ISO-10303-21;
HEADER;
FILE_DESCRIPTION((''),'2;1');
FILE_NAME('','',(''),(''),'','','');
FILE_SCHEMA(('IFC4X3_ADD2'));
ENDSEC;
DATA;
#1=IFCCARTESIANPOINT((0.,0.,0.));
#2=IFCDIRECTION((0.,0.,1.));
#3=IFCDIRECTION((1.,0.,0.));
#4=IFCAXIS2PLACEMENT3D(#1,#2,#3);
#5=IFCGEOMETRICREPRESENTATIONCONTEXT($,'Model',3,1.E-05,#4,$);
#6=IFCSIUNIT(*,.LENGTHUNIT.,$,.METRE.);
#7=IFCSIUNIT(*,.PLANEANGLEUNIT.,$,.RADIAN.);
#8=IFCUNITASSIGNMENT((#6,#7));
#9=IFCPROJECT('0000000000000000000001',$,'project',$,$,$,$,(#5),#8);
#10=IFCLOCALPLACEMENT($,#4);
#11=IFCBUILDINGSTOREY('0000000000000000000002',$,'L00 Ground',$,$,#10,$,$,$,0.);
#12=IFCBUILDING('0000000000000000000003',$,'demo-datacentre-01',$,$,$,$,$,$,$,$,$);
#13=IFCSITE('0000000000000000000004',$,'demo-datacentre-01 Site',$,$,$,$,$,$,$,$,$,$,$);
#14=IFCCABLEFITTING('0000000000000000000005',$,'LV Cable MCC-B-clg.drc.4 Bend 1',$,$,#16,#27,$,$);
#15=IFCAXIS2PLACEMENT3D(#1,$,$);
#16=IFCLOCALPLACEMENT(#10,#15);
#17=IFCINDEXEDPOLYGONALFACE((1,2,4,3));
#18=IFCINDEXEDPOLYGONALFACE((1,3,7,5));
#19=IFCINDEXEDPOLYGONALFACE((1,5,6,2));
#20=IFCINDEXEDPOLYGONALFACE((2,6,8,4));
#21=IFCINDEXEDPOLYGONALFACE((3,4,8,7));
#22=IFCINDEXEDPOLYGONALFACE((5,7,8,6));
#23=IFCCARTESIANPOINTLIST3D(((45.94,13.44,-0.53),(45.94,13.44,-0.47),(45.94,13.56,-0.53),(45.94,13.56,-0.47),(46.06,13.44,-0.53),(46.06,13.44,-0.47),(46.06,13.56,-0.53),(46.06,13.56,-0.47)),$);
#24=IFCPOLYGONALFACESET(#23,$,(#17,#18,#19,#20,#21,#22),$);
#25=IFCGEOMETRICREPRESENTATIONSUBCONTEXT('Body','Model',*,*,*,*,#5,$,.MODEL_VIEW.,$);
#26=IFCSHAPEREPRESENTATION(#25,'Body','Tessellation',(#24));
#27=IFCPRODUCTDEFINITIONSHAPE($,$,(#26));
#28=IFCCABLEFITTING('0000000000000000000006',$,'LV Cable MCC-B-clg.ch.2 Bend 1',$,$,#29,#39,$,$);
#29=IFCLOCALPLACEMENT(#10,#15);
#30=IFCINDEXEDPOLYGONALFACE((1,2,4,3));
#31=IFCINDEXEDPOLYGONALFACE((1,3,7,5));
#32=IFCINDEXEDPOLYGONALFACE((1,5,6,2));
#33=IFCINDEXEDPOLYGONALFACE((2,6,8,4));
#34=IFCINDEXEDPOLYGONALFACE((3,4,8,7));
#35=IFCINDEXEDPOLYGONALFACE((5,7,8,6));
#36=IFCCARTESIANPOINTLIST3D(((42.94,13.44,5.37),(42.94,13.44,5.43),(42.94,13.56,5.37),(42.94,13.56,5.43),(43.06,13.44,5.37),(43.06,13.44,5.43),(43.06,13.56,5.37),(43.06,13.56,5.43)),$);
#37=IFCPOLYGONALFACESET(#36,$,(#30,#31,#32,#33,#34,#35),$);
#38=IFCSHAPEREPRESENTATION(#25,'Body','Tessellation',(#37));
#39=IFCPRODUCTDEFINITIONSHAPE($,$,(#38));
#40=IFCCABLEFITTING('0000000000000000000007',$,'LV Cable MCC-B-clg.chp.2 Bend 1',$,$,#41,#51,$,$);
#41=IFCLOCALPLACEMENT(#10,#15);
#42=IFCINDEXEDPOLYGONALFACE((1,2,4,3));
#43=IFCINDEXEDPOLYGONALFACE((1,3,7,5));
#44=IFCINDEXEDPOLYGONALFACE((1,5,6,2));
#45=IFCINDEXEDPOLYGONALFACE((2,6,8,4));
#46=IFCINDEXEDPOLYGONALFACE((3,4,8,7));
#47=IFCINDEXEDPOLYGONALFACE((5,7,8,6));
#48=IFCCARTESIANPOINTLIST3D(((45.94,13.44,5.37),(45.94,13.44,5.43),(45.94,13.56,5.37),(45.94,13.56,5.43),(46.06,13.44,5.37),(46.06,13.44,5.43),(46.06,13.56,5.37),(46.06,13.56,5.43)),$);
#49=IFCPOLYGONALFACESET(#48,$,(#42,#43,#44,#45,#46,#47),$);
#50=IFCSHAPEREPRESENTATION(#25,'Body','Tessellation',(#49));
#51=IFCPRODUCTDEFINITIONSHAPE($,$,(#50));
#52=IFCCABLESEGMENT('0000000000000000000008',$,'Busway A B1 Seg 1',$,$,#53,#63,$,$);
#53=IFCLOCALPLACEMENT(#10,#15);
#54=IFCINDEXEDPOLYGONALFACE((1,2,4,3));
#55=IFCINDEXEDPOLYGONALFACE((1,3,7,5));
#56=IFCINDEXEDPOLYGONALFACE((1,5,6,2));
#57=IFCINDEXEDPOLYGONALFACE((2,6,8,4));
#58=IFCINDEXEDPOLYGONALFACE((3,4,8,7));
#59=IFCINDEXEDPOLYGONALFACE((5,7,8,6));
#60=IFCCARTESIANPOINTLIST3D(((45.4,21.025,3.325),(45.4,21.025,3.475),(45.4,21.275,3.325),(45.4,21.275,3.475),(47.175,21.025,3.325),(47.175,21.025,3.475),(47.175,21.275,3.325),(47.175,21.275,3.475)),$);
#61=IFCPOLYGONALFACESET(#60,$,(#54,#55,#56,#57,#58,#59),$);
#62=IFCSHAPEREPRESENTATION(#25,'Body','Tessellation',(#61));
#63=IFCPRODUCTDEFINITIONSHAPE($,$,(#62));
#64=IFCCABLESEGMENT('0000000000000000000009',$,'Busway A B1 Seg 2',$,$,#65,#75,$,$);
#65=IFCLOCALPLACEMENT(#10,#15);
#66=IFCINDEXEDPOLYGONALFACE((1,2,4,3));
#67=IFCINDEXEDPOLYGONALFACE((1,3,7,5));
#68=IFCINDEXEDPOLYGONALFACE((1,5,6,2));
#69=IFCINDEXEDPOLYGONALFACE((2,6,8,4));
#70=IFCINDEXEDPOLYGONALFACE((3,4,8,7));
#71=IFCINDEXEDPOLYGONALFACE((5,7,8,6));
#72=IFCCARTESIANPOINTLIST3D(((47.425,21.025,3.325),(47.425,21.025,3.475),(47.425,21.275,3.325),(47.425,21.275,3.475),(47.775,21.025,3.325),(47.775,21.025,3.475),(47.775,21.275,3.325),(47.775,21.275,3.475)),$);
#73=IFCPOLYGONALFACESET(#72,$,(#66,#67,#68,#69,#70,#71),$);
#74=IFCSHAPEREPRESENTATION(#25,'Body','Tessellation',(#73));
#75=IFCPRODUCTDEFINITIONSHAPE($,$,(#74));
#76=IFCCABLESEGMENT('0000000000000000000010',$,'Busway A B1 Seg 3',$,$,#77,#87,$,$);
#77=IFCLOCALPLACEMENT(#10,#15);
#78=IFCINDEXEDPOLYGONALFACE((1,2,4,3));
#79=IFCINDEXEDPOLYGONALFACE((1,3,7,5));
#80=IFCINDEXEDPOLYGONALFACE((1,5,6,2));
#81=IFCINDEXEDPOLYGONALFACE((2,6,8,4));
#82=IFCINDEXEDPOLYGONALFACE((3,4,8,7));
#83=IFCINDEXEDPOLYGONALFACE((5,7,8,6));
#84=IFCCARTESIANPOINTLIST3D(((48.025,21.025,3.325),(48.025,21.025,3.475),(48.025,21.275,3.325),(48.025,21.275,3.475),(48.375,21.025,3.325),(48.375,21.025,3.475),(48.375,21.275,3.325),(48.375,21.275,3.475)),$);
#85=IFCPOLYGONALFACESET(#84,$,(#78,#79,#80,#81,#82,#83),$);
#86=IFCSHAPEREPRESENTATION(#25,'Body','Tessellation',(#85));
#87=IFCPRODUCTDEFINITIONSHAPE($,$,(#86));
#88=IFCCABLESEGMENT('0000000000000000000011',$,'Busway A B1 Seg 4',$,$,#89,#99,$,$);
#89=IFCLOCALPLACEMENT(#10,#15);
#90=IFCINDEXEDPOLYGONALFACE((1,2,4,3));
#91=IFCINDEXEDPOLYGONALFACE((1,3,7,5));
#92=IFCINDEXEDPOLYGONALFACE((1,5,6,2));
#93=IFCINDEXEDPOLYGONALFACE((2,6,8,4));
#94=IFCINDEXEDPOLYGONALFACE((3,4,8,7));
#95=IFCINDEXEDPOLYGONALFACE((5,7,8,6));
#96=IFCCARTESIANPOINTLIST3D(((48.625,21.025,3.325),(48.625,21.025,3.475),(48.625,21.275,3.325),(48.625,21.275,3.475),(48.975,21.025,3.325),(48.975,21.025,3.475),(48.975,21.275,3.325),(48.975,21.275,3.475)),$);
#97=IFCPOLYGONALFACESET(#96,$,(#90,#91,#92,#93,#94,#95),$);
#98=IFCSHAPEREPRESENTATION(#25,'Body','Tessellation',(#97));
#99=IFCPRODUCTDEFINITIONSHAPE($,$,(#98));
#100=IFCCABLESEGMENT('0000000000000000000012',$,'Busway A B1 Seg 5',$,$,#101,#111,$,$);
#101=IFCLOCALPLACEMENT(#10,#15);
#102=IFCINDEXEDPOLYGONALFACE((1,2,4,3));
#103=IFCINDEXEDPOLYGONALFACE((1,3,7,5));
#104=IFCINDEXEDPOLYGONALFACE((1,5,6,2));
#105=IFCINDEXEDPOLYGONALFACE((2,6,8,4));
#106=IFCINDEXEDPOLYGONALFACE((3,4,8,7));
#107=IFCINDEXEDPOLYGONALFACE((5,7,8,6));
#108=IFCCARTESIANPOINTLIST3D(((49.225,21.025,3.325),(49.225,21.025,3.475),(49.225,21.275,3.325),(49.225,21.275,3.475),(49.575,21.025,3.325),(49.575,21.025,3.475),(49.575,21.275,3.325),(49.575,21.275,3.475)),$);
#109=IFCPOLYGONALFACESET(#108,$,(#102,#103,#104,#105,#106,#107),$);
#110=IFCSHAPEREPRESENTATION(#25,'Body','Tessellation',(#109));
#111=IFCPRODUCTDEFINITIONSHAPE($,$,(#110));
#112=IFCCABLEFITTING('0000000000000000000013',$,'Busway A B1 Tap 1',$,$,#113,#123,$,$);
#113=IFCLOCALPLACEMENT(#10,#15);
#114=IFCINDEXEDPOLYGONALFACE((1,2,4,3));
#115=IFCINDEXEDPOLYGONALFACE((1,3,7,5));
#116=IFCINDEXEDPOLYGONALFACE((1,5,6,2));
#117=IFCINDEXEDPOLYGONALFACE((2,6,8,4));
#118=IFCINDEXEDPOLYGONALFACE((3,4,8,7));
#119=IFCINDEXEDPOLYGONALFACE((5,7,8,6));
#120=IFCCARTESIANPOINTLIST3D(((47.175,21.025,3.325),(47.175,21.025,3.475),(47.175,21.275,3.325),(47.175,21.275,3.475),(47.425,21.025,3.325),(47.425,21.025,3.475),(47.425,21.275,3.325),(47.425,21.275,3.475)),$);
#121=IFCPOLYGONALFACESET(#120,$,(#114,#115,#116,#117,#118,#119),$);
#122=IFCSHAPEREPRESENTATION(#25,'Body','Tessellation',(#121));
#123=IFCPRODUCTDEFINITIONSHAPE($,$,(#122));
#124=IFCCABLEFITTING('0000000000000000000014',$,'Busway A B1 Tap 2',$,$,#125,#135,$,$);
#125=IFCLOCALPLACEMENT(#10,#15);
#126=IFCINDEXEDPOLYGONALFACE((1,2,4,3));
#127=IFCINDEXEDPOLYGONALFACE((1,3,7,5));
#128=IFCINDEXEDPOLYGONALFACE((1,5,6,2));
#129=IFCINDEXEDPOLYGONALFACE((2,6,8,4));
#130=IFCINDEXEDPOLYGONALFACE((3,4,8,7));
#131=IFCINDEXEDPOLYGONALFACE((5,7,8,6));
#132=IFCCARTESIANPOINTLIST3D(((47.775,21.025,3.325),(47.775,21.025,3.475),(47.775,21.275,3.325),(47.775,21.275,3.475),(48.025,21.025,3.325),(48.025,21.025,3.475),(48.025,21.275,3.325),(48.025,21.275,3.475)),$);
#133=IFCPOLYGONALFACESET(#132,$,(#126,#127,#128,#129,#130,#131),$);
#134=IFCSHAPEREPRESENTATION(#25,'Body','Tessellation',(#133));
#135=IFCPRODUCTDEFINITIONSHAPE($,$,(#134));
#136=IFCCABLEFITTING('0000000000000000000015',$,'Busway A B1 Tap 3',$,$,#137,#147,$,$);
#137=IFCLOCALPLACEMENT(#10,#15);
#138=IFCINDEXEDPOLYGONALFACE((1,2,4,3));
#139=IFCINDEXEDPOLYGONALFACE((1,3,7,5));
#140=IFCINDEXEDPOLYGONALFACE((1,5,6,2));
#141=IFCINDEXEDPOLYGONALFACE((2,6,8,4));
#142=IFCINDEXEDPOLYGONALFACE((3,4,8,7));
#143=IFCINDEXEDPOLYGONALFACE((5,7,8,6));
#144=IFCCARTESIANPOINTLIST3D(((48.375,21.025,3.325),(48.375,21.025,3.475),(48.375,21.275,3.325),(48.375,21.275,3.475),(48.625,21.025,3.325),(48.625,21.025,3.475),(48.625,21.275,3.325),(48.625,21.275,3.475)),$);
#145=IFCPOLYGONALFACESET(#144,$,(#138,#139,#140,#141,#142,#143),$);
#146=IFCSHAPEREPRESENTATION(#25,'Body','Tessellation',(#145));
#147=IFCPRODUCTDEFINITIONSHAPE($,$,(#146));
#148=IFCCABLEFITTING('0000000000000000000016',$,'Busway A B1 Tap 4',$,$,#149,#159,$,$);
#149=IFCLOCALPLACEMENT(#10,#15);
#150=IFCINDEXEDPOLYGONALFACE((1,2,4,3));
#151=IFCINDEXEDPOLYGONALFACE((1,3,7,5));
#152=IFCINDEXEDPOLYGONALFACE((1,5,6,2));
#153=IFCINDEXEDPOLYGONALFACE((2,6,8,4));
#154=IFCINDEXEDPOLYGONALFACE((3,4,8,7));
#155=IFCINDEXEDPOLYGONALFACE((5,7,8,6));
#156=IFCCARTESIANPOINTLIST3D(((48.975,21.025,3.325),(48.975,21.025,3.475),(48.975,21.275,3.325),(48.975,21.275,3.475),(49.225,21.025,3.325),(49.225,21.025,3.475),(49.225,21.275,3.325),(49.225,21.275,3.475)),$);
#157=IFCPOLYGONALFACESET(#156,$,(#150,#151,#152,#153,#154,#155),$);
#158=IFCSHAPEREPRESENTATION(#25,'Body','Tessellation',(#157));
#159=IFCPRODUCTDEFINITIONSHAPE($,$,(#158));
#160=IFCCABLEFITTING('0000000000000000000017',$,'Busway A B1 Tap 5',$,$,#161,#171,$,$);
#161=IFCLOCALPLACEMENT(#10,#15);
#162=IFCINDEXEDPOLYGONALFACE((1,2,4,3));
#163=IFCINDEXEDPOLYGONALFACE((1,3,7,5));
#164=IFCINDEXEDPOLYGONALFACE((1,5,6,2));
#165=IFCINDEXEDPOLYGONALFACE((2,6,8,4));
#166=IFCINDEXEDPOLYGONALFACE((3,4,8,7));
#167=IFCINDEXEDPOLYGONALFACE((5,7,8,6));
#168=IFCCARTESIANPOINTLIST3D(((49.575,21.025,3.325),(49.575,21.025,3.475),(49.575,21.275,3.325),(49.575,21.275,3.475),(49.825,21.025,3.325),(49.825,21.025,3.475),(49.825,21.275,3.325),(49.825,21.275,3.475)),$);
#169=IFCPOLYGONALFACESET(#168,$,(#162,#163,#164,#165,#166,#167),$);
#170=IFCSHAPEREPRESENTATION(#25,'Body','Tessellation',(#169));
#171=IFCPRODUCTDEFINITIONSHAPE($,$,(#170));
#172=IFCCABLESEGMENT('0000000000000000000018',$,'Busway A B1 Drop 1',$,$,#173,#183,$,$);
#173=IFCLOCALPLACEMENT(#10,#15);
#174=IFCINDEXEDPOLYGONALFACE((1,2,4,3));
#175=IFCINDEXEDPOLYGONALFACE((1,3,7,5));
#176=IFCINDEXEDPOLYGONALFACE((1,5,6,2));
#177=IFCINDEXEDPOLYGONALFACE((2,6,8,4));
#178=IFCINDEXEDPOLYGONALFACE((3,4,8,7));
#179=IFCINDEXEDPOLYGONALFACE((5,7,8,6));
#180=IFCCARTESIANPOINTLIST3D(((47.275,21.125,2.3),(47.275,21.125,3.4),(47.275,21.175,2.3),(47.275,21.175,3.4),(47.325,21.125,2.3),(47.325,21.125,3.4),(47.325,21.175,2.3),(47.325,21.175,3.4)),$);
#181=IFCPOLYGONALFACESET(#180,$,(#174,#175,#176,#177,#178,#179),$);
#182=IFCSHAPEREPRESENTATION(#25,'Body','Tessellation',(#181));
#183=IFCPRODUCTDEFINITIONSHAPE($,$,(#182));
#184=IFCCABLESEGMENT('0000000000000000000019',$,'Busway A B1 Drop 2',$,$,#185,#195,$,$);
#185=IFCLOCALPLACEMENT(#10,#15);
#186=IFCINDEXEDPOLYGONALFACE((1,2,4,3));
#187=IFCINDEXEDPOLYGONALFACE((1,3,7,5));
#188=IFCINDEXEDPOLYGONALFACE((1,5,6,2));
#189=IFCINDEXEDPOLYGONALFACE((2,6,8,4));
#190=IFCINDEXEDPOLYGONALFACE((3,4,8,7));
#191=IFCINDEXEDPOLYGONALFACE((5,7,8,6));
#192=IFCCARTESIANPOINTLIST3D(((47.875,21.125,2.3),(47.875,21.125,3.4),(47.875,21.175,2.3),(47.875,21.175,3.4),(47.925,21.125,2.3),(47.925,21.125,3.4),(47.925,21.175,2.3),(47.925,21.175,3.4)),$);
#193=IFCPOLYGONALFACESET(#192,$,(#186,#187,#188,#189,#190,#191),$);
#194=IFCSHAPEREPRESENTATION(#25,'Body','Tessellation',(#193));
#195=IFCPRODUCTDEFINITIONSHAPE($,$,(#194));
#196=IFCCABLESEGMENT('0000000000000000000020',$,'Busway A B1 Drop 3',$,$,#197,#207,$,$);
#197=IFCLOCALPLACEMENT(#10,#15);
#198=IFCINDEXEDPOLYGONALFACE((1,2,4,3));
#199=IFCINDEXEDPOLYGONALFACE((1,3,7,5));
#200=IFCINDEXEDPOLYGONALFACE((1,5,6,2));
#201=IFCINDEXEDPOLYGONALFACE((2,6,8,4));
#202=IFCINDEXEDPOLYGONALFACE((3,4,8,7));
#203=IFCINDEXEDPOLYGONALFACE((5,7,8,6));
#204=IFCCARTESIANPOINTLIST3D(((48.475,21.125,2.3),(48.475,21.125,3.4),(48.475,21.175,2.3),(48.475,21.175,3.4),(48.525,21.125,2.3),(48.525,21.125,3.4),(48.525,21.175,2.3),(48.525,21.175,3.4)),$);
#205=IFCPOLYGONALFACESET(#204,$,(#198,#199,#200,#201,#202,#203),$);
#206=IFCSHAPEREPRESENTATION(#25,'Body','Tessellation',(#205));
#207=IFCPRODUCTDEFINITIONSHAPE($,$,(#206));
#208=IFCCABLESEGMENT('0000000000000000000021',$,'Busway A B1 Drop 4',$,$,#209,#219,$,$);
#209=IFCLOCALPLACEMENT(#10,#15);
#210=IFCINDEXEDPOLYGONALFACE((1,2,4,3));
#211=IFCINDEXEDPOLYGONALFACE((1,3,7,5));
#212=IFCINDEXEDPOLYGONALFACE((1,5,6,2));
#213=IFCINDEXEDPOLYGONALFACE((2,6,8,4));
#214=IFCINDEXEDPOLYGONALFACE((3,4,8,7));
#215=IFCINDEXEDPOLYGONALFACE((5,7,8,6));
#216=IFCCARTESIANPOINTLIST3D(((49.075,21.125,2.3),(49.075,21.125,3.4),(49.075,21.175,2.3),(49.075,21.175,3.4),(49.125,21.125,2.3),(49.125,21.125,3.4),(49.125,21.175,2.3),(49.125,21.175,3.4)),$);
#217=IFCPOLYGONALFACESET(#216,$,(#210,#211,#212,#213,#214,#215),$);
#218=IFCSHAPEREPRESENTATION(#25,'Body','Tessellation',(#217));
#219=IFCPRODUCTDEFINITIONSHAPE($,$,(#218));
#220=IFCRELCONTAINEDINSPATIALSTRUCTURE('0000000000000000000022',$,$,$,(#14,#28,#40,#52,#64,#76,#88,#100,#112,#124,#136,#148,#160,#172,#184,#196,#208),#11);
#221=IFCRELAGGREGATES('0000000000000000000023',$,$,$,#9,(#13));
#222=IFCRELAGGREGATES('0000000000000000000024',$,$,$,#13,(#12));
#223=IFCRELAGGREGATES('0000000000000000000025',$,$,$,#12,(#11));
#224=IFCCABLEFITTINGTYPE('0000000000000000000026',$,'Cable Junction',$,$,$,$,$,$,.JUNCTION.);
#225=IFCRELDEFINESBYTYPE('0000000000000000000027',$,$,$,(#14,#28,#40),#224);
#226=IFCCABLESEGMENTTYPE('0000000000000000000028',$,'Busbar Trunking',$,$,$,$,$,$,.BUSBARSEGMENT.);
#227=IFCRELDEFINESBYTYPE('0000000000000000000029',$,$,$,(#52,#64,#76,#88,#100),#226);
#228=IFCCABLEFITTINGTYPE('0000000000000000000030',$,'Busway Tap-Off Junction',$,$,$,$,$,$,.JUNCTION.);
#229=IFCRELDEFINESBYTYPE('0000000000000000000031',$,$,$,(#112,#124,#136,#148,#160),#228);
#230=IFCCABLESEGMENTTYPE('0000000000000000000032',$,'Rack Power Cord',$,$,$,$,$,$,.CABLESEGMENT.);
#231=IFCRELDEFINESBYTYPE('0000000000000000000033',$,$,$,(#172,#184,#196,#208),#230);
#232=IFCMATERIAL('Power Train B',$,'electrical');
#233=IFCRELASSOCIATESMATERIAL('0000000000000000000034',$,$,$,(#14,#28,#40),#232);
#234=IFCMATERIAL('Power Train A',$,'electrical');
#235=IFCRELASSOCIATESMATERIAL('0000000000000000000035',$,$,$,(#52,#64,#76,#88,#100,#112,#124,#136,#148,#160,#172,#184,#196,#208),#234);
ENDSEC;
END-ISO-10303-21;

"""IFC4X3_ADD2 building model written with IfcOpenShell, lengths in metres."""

from ifc_helpers import new_model, si_unit, frame, origin_with_axes, place, context, subcontext, project, spatial, rectangle, extrude, material, type_object, element, save


model = new_model("IFC4X3_ADD2")

# Units and contexts
model_context = context("Model", 3, precision=1e-05, world=origin_with_axes())
body_context = subcontext(model_context, "Body", "Model", "MODEL_VIEW")
ifc_project = project(units=[si_unit("LENGTHUNIT", "METRE"), si_unit("PLANEANGLEUNIT", "RADIAN")], contexts=[model_context])

# Site, building, storey
site = spatial("IfcSite", under=ifc_project, Name="demo-datacentre-01 Site")
building = spatial("IfcBuilding", under=site, Name="demo-datacentre-01")
storey_placement = place(None, origin_with_axes())
storey = spatial("IfcBuildingStorey", under=building, at=storey_placement, Name="L00 Ground", Elevation=0.0)

# Shared definitions
ifc_material_1 = material(Name="Power Train A", Category="electrical")
ifc_material_2 = material(Name="Power Train B", Category="electrical")

# Cable fittings
cable_fitting_type_1 = type_object("IfcCableFittingType", Name="Cable Junction", PredefinedType="JUNCTION")
for number, where, z_axis, x_axis, name in (
    (1, (46.0, 13.5, -0.53), (0.0, 0.0, 1.0), (1.0, 0.0, 0.0), "LV Cable MCC-B-clg.drc.4 Bend 1"),
    (2, (43.0, 13.5, 5.37), (0.0, 0.0, 1.0), (1.0, 0.0, 0.0), "LV Cable MCC-B-clg.ch.2 Bend 1"),
    (3, (46.0, 13.5, 5.37), (0.0, 0.0, 1.0), (1.0, 0.0, 0.0), "LV Cable MCC-B-clg.chp.2 Bend 1"),
):
    element("IfcCableFitting", number, at=place(storey_placement, frame(where, z_axis=z_axis, x_axis=x_axis)), inside=storey, type_object=cable_fitting_type_1, material=ifc_material_2, Name=name, context=body_context, shape_type="SweptSolid", body=[
        extrude(rectangle(XDim=0.12, YDim=0.12), origin_with_axes(), (0.0, 0.0, 1.0), 0.06),
    ])

# Cable segments
cable_segment_type_1 = type_object("IfcCableSegmentType", Name="Busbar Trunking", PredefinedType="BUSBARSEGMENT")
cable_segment_1_placement = place(storey_placement, frame((45.4, 21.15, 3.4), z_axis=(1.0, 0.0, 0.0), x_axis=(0.0, 1.0, 0.0)))
element("IfcCableSegment", 4, at=cable_segment_1_placement, inside=storey, type_object=cable_segment_type_1, material=ifc_material_1, Name="Busway A B1 Seg 1", context=body_context, shape_type="SweptSolid", body=[
    extrude(rectangle(XDim=0.25, YDim=0.15), origin_with_axes(), (0.0, 0.0, 1.0), 1.775),
])
for number, where, z_axis, x_axis, name in (
    (5, (47.425, 21.15, 3.4), (1.0, 0.0, 0.0), (0.0, 1.0, 0.0), "Busway A B1 Seg 2"),
    (6, (48.025, 21.15, 3.4), (1.0, 0.0, 0.0), (0.0, 1.0, 0.0), "Busway A B1 Seg 3"),
):
    element("IfcCableSegment", number, at=place(storey_placement, frame(where, z_axis=z_axis, x_axis=x_axis)), inside=storey, type_object=cable_segment_type_1, material=ifc_material_1, Name=name, context=body_context, shape_type="SweptSolid", body=[
        extrude(rectangle(XDim=0.25, YDim=0.15), origin_with_axes(), (0.0, 0.0, 1.0), 0.35),
    ])
cable_segment_2_placement = place(storey_placement, frame((48.625, 21.15, 3.4), z_axis=(1.0, 0.0, 0.0), x_axis=(0.0, 1.0, 0.0)))
element("IfcCableSegment", 7, at=cable_segment_2_placement, inside=storey, type_object=cable_segment_type_1, material=ifc_material_1, Name="Busway A B1 Seg 4", context=body_context, shape_type="SweptSolid", body=[
    extrude(rectangle(XDim=0.25, YDim=0.15), origin_with_axes(), (0.0, 0.0, 1.0), 0.35),
])
cable_segment_3_placement = place(storey_placement, frame((49.225, 21.15, 3.4), z_axis=(1.0, 0.0, 0.0), x_axis=(0.0, 1.0, 0.0)))
element("IfcCableSegment", 8, at=cable_segment_3_placement, inside=storey, type_object=cable_segment_type_1, material=ifc_material_1, Name="Busway A B1 Seg 5", context=body_context, shape_type="SweptSolid", body=[
    extrude(rectangle(XDim=0.25, YDim=0.15), origin_with_axes(), (0.0, 0.0, 1.0), 0.35),
])

# Cable fittings
cable_fitting_type_2 = type_object("IfcCableFittingType", Name="Busway Tap-Off Junction", PredefinedType="JUNCTION")
for number, where, z_axis, x_axis, name in (
    (9, (47.3, 21.15, 3.325), (0.0, 0.0, 1.0), (1.0, 0.0, 0.0), "Busway A B1 Tap 1"),
    (10, (47.9, 21.15, 3.325), (0.0, 0.0, 1.0), (1.0, 0.0, 0.0), "Busway A B1 Tap 2"),
    (11, (48.5, 21.15, 3.325), (0.0, 0.0, 1.0), (1.0, 0.0, 0.0), "Busway A B1 Tap 3"),
    (12, (49.1, 21.15, 3.325), (0.0, 0.0, 1.0), (1.0, 0.0, 0.0), "Busway A B1 Tap 4"),
    (13, (49.7, 21.15, 3.325), (0.0, 0.0, 1.0), (1.0, 0.0, 0.0), "Busway A B1 Tap 5"),
):
    element("IfcCableFitting", number, at=place(storey_placement, frame(where, z_axis=z_axis, x_axis=x_axis)), inside=storey, type_object=cable_fitting_type_2, material=ifc_material_1, Name=name, context=body_context, shape_type="SweptSolid", body=[
        extrude(rectangle(XDim=0.25, YDim=0.25), origin_with_axes(), (0.0, 0.0, 1.0), 0.15),
    ])

# Cable segments
cable_segment_type_2 = type_object("IfcCableSegmentType", Name="Rack Power Cord", PredefinedType="CABLESEGMENT")
for number, where, z_axis, x_axis, name in (
    (14, (47.3, 21.15, 3.4), (0.0, 0.0, -1.0), (1.0, 0.0, 0.0), "Busway A B1 Drop 1"),
    (15, (47.9, 21.15, 3.4), (0.0, 0.0, -1.0), (1.0, 0.0, 0.0), "Busway A B1 Drop 2"),
    (16, (48.5, 21.15, 3.4), (0.0, 0.0, -1.0), (1.0, 0.0, 0.0), "Busway A B1 Drop 3"),
    (17, (49.1, 21.15, 3.4), (0.0, 0.0, -1.0), (1.0, 0.0, 0.0), "Busway A B1 Drop 4"),
):
    element("IfcCableSegment", number, at=place(storey_placement, frame(where, z_axis=z_axis, x_axis=x_axis)), inside=storey, type_object=cable_segment_type_2, material=ifc_material_1, Name=name, context=body_context, shape_type="SweptSolid", body=[
        extrude(rectangle(XDim=0.05, YDim=0.05), origin_with_axes(), (0.0, 0.0, 1.0), 1.1),
    ])

save(model, "model.ifc")
